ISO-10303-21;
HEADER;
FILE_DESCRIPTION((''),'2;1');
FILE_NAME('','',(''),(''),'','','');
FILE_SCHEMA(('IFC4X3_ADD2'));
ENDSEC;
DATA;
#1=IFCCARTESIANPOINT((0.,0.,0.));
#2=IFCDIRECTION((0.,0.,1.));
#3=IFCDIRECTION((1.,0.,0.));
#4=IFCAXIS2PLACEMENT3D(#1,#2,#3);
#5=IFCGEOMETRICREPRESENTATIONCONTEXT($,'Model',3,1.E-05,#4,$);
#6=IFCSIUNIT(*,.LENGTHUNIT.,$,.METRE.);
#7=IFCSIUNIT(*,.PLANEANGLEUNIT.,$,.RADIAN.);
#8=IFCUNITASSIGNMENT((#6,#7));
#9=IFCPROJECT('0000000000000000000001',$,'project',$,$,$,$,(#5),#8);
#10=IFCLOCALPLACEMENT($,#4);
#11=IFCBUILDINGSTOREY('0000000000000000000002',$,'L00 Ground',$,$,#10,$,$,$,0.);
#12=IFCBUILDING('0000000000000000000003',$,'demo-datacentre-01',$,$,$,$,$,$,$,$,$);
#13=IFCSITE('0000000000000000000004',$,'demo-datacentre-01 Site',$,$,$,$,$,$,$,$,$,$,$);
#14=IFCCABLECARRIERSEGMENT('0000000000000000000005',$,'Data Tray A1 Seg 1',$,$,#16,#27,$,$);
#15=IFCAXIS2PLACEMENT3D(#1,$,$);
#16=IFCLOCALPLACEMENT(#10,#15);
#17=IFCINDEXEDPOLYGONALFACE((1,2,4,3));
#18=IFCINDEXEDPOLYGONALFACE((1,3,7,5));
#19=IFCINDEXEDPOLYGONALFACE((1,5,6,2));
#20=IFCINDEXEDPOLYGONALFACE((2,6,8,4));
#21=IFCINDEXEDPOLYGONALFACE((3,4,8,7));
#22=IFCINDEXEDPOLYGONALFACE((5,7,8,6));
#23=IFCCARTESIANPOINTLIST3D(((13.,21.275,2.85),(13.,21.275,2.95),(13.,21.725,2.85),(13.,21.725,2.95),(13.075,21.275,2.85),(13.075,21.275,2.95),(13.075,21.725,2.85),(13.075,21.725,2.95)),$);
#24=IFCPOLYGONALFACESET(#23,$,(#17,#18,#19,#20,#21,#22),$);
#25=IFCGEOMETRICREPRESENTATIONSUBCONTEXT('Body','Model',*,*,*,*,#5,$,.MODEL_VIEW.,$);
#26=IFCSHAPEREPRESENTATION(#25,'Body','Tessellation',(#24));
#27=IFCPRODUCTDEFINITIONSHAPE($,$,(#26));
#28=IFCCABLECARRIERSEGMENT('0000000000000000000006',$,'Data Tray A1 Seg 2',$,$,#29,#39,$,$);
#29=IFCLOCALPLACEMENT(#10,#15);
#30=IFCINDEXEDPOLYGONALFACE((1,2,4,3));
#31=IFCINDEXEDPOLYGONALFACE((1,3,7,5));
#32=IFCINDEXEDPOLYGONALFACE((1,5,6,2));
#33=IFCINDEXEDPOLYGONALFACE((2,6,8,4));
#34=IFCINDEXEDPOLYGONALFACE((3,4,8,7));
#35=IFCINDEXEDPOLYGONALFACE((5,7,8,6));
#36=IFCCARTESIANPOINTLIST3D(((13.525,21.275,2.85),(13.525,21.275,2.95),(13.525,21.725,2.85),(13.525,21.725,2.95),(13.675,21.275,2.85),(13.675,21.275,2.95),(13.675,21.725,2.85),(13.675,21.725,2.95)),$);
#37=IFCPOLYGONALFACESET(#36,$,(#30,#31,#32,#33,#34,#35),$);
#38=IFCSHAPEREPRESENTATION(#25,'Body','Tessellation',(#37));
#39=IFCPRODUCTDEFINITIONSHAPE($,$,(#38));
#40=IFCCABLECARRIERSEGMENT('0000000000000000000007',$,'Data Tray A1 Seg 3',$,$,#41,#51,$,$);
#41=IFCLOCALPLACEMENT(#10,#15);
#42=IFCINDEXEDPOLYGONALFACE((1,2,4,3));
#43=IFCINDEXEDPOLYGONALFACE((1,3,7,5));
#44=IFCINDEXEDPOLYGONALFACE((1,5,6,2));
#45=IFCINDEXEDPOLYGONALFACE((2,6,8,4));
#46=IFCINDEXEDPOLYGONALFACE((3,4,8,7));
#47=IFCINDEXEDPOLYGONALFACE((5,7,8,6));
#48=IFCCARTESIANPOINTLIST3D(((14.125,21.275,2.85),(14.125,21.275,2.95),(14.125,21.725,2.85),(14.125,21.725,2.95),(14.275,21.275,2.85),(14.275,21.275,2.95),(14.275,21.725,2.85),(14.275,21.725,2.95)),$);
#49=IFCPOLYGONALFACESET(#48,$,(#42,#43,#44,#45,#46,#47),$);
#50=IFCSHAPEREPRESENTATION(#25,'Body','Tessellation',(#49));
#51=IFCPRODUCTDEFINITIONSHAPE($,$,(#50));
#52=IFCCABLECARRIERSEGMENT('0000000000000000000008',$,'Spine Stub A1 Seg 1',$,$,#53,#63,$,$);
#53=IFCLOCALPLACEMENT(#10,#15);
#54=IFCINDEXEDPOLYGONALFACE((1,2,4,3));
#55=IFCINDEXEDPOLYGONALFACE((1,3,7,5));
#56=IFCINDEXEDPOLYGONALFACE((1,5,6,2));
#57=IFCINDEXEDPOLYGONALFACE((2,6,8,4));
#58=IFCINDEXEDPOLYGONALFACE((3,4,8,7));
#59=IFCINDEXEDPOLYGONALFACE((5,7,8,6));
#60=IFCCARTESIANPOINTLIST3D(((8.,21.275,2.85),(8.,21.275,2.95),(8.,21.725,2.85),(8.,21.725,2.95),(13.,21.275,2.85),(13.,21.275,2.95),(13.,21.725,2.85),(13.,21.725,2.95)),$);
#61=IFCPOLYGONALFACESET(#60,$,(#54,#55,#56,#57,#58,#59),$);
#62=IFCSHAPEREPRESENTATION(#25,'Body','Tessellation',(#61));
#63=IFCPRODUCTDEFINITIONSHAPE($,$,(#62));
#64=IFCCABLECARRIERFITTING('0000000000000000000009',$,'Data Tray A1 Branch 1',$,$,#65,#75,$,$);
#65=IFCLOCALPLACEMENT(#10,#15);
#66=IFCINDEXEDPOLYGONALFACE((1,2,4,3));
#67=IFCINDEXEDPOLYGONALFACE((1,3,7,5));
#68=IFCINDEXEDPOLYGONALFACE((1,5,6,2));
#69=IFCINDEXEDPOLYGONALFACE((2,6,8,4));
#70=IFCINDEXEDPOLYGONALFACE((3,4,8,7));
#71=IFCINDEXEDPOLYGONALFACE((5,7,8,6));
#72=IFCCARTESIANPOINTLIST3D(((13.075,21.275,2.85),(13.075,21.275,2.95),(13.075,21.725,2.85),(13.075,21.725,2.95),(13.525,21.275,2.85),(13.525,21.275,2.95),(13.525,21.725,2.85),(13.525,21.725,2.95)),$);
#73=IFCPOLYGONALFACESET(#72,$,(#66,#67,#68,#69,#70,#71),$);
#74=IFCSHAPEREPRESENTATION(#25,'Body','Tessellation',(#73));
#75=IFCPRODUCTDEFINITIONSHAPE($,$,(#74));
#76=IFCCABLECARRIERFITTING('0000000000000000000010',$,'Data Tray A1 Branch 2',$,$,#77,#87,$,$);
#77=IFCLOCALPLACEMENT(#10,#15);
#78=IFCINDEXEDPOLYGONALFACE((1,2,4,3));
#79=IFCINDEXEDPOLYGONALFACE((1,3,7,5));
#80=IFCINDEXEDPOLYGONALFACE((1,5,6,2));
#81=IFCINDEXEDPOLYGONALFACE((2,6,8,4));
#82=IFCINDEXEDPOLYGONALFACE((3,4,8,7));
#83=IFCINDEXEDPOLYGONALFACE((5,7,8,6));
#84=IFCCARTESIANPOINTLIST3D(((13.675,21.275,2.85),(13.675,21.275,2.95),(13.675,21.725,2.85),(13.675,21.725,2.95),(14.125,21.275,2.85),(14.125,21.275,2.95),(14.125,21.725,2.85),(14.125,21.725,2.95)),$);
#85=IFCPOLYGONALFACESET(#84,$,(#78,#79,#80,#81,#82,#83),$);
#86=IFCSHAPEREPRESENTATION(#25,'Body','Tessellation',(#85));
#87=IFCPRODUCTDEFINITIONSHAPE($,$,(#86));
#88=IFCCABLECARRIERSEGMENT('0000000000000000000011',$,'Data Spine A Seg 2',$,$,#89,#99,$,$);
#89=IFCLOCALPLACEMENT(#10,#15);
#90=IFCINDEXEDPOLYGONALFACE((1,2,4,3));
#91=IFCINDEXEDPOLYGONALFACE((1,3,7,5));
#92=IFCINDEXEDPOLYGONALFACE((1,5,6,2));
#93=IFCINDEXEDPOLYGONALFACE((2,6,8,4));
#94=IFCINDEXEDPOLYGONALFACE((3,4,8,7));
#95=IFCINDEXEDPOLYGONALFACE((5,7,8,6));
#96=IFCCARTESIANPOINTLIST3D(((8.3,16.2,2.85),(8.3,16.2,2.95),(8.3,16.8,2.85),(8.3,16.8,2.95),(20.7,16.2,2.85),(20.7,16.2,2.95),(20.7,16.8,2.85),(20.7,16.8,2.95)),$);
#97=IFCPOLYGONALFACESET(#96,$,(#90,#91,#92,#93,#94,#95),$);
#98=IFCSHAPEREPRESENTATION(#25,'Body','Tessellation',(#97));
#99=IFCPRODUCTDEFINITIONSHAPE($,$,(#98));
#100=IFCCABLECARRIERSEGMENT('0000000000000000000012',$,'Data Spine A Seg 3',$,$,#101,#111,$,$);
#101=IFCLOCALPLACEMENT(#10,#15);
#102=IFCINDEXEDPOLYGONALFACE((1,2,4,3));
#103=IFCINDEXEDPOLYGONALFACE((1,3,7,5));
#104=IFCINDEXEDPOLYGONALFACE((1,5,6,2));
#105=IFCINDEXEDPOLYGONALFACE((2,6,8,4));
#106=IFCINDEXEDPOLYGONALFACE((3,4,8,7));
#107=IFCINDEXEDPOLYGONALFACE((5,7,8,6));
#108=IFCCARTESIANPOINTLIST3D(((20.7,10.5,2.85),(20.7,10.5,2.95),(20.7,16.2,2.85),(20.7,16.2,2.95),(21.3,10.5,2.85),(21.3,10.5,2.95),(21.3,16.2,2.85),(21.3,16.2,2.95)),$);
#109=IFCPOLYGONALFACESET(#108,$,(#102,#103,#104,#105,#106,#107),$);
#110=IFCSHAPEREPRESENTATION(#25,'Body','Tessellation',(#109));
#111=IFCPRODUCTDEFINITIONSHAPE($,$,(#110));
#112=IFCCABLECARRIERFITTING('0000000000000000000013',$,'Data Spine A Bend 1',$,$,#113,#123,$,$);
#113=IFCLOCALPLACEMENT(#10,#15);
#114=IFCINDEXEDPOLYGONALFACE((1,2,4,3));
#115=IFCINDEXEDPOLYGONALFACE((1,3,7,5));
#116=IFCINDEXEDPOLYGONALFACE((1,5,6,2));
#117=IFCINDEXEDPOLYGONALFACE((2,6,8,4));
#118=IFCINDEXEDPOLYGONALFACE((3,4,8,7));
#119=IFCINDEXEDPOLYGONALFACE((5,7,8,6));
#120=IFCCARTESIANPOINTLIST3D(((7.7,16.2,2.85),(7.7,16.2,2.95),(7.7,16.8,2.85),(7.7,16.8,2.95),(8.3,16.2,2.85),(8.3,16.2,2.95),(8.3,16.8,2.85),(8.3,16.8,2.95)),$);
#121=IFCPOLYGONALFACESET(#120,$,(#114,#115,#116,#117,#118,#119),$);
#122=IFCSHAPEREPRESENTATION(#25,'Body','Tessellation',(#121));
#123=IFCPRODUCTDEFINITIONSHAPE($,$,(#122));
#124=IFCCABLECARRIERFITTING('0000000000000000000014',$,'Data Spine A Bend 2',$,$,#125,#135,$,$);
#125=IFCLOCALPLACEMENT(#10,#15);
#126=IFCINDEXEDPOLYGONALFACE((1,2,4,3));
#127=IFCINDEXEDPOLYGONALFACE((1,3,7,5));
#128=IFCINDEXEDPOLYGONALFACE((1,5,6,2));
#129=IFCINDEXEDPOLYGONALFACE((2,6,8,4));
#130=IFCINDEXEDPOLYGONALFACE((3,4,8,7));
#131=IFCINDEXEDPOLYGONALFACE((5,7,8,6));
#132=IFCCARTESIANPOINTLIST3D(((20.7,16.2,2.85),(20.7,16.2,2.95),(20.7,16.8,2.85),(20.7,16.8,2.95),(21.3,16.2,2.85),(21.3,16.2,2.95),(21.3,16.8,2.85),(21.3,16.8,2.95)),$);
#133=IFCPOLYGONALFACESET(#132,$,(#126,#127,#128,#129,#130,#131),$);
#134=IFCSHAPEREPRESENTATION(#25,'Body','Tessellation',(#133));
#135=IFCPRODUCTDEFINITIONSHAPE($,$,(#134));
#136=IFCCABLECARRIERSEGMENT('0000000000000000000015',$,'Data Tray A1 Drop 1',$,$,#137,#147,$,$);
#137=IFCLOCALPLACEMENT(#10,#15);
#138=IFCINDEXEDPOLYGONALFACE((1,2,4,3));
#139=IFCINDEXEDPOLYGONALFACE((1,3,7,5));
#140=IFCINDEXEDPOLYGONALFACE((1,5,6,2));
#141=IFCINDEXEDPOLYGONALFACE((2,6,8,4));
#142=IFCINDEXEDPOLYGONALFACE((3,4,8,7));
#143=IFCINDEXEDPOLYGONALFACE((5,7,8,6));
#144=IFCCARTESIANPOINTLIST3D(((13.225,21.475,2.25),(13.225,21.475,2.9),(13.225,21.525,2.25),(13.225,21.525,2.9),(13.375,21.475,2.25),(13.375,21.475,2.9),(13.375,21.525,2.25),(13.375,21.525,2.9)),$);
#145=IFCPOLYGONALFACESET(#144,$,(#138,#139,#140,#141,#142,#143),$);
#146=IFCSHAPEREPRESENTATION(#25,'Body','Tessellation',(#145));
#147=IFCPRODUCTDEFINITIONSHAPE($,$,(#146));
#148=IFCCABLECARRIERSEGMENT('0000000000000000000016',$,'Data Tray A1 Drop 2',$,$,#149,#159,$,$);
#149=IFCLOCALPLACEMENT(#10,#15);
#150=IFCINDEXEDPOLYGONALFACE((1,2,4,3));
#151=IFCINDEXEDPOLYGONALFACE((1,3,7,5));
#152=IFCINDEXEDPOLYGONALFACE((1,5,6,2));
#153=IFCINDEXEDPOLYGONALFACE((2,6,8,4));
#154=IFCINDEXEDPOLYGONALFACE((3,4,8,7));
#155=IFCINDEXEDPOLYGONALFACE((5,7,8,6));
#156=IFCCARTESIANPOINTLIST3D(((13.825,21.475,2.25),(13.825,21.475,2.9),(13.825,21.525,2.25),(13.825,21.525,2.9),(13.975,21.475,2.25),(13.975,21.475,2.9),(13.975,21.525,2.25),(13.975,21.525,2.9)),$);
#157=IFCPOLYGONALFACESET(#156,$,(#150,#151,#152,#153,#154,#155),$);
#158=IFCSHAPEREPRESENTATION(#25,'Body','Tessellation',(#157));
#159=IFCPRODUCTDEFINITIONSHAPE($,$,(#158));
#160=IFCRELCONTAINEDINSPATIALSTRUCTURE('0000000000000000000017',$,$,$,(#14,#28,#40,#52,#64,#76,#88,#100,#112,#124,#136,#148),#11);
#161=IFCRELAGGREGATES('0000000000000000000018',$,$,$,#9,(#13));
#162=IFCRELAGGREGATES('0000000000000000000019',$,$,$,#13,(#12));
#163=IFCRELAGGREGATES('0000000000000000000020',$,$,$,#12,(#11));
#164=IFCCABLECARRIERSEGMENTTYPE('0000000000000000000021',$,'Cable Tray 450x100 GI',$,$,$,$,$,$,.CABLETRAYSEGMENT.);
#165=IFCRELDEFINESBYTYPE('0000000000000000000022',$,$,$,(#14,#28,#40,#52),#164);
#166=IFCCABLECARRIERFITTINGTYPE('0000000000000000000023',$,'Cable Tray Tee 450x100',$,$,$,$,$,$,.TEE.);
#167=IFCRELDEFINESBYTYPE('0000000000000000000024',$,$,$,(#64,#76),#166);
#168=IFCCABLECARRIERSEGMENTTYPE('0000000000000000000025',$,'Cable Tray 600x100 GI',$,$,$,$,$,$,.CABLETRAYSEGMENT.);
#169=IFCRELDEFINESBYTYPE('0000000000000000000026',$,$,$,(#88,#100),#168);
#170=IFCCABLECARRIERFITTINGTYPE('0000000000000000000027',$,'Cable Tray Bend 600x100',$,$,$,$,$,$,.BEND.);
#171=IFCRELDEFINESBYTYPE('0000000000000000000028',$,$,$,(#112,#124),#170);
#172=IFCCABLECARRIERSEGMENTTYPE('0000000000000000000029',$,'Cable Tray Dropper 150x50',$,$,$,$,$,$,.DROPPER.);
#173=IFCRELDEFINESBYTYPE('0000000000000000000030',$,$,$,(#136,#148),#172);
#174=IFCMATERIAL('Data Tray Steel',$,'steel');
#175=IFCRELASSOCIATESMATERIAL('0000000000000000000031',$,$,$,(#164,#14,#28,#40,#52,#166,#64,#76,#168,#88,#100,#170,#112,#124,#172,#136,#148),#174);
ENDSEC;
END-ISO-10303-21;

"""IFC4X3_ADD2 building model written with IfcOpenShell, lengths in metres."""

from ifc_helpers import new_model, si_unit, frame, origin_with_axes, place, context, subcontext, project, spatial, rectangle, extrude, material, type_object, element, save


model = new_model("IFC4X3_ADD2")

# Units and contexts
model_context = context("Model", 3, precision=1e-05, world=origin_with_axes())
body_context = subcontext(model_context, "Body", "Model", "MODEL_VIEW")
ifc_project = project(units=[si_unit("LENGTHUNIT", "METRE"), si_unit("PLANEANGLEUNIT", "RADIAN")], contexts=[model_context])

# Site, building, storey
site = spatial("IfcSite", under=ifc_project, Name="demo-datacentre-01 Site")
building = spatial("IfcBuilding", under=site, Name="demo-datacentre-01")
storey_placement = place(None, origin_with_axes())
storey = spatial("IfcBuildingStorey", under=building, at=storey_placement, Name="L00 Ground", Elevation=0.0)

# Cable carrier segments
ifc_material_1 = material(Name="Data Tray Steel", Category="steel")
cable_carrier_segment_type_1 = type_object("IfcCableCarrierSegmentType", Name="Cable Tray 450x100 GI", PredefinedType="CABLETRAYSEGMENT", material=ifc_material_1)
cable_carrier_segment_1_placement = place(storey_placement, frame((13.0, 21.5, 2.9), z_axis=(1.0, 0.0, 0.0), x_axis=(0.0, 1.0, 0.0)))
element("IfcCableCarrierSegment", 1, at=cable_carrier_segment_1_placement, inside=storey, type_object=cable_carrier_segment_type_1, material=ifc_material_1, Name="Data Tray A1 Seg 1", context=body_context, shape_type="SweptSolid", body=[
    extrude(rectangle(XDim=0.45, YDim=0.1), origin_with_axes(), (0.0, 0.0, 1.0), 0.075),
])
for number, where, z_axis, x_axis, name in (
    (2, (13.525, 21.5, 2.9), (1.0, 0.0, 0.0), (0.0, 1.0, 0.0), "Data Tray A1 Seg 2"),
    (3, (14.125, 21.5, 2.9), (1.0, 0.0, 0.0), (0.0, 1.0, 0.0), "Data Tray A1 Seg 3"),
):
    element("IfcCableCarrierSegment", number, at=place(storey_placement, frame(where, z_axis=z_axis, x_axis=x_axis)), inside=storey, type_object=cable_carrier_segment_type_1, material=ifc_material_1, Name=name, context=body_context, shape_type="SweptSolid", body=[
        extrude(rectangle(XDim=0.45, YDim=0.1), origin_with_axes(), (0.0, 0.0, 1.0), 0.15),
    ])
cable_carrier_segment_2_placement = place(storey_placement, frame((8.0, 21.5, 2.9), z_axis=(1.0, 0.0, 0.0), x_axis=(0.0, 1.0, 0.0)))
element("IfcCableCarrierSegment", 4, at=cable_carrier_segment_2_placement, inside=storey, type_object=cable_carrier_segment_type_1, material=ifc_material_1, Name="Spine Stub A1 Seg 1", context=body_context, shape_type="SweptSolid", body=[
    extrude(rectangle(XDim=0.45, YDim=0.1), origin_with_axes(), (0.0, 0.0, 1.0), 5.0),
])

# Cable carrier fittings
cable_carrier_fitting_type_1 = type_object("IfcCableCarrierFittingType", Name="Cable Tray Tee 450x100", PredefinedType="TEE", material=ifc_material_1)
for number, where, z_axis, x_axis, name in (
    (5, (13.3, 21.5, 2.85), (0.0, 0.0, 1.0), (1.0, 0.0, 0.0), "Data Tray A1 Branch 1"),
    (6, (13.9, 21.5, 2.85), (0.0, 0.0, 1.0), (1.0, 0.0, 0.0), "Data Tray A1 Branch 2"),
):
    element("IfcCableCarrierFitting", number, at=place(storey_placement, frame(where, z_axis=z_axis, x_axis=x_axis)), inside=storey, type_object=cable_carrier_fitting_type_1, material=ifc_material_1, Name=name, context=body_context, shape_type="SweptSolid", body=[
        extrude(rectangle(XDim=0.45, YDim=0.45), origin_with_axes(), (0.0, 0.0, 1.0), 0.1),
    ])

# Cable carrier segments
cable_carrier_segment_type_2 = type_object("IfcCableCarrierSegmentType", Name="Cable Tray 600x100 GI", PredefinedType="CABLETRAYSEGMENT", material=ifc_material_1)
cable_carrier_segment_3_placement = place(storey_placement, frame((8.3, 16.5, 2.9), z_axis=(1.0, 0.0, 0.0), x_axis=(0.0, 1.0, 0.0)))
element("IfcCableCarrierSegment", 7, at=cable_carrier_segment_3_placement, inside=storey, type_object=cable_carrier_segment_type_2, material=ifc_material_1, Name="Data Spine A Seg 2", context=body_context, shape_type="SweptSolid", body=[
    extrude(rectangle(XDim=0.6, YDim=0.1), origin_with_axes(), (0.0, 0.0, 1.0), 12.4),
])
cable_carrier_segment_4_placement = place(storey_placement, frame((21.0, 16.2, 2.9), z_axis=(0.0, -1.0, 0.0), x_axis=(1.0, 0.0, 0.0)))
element("IfcCableCarrierSegment", 8, at=cable_carrier_segment_4_placement, inside=storey, type_object=cable_carrier_segment_type_2, material=ifc_material_1, Name="Data Spine A Seg 3", context=body_context, shape_type="SweptSolid", body=[
    extrude(rectangle(XDim=0.6, YDim=0.1), origin_with_axes(), (0.0, 0.0, 1.0), 5.7),
])

# Cable carrier fittings
cable_carrier_fitting_type_2 = type_object("IfcCableCarrierFittingType", Name="Cable Tray Bend 600x100", PredefinedType="BEND", material=ifc_material_1)
for number, where, z_axis, x_axis, name in (
    (9, (8.0, 16.5, 2.85), (0.0, 0.0, 1.0), (1.0, 0.0, 0.0), "Data Spine A Bend 1"),
    (10, (21.0, 16.5, 2.85), (0.0, 0.0, 1.0), (1.0, 0.0, 0.0), "Data Spine A Bend 2"),
):
    element("IfcCableCarrierFitting", number, at=place(storey_placement, frame(where, z_axis=z_axis, x_axis=x_axis)), inside=storey, type_object=cable_carrier_fitting_type_2, material=ifc_material_1, Name=name, context=body_context, shape_type="SweptSolid", body=[
        extrude(rectangle(XDim=0.6, YDim=0.6), origin_with_axes(), (0.0, 0.0, 1.0), 0.1),
    ])

# Cable carrier segments
cable_carrier_segment_type_3 = type_object("IfcCableCarrierSegmentType", Name="Cable Tray Dropper 150x50", PredefinedType="DROPPER", material=ifc_material_1)
for number, where, z_axis, x_axis, name in (
    (11, (13.3, 21.5, 2.9), (0.0, 0.0, -1.0), (1.0, 0.0, 0.0), "Data Tray A1 Drop 1"),
    (12, (13.9, 21.5, 2.9), (0.0, 0.0, -1.0), (1.0, 0.0, 0.0), "Data Tray A1 Drop 2"),
):
    element("IfcCableCarrierSegment", number, at=place(storey_placement, frame(where, z_axis=z_axis, x_axis=x_axis)), inside=storey, type_object=cable_carrier_segment_type_3, material=ifc_material_1, Name=name, context=body_context, shape_type="SweptSolid", body=[
        extrude(rectangle(XDim=0.15, YDim=0.05), origin_with_axes(), (0.0, 0.0, 1.0), 0.65),
    ])

save(model, "model.ifc")
